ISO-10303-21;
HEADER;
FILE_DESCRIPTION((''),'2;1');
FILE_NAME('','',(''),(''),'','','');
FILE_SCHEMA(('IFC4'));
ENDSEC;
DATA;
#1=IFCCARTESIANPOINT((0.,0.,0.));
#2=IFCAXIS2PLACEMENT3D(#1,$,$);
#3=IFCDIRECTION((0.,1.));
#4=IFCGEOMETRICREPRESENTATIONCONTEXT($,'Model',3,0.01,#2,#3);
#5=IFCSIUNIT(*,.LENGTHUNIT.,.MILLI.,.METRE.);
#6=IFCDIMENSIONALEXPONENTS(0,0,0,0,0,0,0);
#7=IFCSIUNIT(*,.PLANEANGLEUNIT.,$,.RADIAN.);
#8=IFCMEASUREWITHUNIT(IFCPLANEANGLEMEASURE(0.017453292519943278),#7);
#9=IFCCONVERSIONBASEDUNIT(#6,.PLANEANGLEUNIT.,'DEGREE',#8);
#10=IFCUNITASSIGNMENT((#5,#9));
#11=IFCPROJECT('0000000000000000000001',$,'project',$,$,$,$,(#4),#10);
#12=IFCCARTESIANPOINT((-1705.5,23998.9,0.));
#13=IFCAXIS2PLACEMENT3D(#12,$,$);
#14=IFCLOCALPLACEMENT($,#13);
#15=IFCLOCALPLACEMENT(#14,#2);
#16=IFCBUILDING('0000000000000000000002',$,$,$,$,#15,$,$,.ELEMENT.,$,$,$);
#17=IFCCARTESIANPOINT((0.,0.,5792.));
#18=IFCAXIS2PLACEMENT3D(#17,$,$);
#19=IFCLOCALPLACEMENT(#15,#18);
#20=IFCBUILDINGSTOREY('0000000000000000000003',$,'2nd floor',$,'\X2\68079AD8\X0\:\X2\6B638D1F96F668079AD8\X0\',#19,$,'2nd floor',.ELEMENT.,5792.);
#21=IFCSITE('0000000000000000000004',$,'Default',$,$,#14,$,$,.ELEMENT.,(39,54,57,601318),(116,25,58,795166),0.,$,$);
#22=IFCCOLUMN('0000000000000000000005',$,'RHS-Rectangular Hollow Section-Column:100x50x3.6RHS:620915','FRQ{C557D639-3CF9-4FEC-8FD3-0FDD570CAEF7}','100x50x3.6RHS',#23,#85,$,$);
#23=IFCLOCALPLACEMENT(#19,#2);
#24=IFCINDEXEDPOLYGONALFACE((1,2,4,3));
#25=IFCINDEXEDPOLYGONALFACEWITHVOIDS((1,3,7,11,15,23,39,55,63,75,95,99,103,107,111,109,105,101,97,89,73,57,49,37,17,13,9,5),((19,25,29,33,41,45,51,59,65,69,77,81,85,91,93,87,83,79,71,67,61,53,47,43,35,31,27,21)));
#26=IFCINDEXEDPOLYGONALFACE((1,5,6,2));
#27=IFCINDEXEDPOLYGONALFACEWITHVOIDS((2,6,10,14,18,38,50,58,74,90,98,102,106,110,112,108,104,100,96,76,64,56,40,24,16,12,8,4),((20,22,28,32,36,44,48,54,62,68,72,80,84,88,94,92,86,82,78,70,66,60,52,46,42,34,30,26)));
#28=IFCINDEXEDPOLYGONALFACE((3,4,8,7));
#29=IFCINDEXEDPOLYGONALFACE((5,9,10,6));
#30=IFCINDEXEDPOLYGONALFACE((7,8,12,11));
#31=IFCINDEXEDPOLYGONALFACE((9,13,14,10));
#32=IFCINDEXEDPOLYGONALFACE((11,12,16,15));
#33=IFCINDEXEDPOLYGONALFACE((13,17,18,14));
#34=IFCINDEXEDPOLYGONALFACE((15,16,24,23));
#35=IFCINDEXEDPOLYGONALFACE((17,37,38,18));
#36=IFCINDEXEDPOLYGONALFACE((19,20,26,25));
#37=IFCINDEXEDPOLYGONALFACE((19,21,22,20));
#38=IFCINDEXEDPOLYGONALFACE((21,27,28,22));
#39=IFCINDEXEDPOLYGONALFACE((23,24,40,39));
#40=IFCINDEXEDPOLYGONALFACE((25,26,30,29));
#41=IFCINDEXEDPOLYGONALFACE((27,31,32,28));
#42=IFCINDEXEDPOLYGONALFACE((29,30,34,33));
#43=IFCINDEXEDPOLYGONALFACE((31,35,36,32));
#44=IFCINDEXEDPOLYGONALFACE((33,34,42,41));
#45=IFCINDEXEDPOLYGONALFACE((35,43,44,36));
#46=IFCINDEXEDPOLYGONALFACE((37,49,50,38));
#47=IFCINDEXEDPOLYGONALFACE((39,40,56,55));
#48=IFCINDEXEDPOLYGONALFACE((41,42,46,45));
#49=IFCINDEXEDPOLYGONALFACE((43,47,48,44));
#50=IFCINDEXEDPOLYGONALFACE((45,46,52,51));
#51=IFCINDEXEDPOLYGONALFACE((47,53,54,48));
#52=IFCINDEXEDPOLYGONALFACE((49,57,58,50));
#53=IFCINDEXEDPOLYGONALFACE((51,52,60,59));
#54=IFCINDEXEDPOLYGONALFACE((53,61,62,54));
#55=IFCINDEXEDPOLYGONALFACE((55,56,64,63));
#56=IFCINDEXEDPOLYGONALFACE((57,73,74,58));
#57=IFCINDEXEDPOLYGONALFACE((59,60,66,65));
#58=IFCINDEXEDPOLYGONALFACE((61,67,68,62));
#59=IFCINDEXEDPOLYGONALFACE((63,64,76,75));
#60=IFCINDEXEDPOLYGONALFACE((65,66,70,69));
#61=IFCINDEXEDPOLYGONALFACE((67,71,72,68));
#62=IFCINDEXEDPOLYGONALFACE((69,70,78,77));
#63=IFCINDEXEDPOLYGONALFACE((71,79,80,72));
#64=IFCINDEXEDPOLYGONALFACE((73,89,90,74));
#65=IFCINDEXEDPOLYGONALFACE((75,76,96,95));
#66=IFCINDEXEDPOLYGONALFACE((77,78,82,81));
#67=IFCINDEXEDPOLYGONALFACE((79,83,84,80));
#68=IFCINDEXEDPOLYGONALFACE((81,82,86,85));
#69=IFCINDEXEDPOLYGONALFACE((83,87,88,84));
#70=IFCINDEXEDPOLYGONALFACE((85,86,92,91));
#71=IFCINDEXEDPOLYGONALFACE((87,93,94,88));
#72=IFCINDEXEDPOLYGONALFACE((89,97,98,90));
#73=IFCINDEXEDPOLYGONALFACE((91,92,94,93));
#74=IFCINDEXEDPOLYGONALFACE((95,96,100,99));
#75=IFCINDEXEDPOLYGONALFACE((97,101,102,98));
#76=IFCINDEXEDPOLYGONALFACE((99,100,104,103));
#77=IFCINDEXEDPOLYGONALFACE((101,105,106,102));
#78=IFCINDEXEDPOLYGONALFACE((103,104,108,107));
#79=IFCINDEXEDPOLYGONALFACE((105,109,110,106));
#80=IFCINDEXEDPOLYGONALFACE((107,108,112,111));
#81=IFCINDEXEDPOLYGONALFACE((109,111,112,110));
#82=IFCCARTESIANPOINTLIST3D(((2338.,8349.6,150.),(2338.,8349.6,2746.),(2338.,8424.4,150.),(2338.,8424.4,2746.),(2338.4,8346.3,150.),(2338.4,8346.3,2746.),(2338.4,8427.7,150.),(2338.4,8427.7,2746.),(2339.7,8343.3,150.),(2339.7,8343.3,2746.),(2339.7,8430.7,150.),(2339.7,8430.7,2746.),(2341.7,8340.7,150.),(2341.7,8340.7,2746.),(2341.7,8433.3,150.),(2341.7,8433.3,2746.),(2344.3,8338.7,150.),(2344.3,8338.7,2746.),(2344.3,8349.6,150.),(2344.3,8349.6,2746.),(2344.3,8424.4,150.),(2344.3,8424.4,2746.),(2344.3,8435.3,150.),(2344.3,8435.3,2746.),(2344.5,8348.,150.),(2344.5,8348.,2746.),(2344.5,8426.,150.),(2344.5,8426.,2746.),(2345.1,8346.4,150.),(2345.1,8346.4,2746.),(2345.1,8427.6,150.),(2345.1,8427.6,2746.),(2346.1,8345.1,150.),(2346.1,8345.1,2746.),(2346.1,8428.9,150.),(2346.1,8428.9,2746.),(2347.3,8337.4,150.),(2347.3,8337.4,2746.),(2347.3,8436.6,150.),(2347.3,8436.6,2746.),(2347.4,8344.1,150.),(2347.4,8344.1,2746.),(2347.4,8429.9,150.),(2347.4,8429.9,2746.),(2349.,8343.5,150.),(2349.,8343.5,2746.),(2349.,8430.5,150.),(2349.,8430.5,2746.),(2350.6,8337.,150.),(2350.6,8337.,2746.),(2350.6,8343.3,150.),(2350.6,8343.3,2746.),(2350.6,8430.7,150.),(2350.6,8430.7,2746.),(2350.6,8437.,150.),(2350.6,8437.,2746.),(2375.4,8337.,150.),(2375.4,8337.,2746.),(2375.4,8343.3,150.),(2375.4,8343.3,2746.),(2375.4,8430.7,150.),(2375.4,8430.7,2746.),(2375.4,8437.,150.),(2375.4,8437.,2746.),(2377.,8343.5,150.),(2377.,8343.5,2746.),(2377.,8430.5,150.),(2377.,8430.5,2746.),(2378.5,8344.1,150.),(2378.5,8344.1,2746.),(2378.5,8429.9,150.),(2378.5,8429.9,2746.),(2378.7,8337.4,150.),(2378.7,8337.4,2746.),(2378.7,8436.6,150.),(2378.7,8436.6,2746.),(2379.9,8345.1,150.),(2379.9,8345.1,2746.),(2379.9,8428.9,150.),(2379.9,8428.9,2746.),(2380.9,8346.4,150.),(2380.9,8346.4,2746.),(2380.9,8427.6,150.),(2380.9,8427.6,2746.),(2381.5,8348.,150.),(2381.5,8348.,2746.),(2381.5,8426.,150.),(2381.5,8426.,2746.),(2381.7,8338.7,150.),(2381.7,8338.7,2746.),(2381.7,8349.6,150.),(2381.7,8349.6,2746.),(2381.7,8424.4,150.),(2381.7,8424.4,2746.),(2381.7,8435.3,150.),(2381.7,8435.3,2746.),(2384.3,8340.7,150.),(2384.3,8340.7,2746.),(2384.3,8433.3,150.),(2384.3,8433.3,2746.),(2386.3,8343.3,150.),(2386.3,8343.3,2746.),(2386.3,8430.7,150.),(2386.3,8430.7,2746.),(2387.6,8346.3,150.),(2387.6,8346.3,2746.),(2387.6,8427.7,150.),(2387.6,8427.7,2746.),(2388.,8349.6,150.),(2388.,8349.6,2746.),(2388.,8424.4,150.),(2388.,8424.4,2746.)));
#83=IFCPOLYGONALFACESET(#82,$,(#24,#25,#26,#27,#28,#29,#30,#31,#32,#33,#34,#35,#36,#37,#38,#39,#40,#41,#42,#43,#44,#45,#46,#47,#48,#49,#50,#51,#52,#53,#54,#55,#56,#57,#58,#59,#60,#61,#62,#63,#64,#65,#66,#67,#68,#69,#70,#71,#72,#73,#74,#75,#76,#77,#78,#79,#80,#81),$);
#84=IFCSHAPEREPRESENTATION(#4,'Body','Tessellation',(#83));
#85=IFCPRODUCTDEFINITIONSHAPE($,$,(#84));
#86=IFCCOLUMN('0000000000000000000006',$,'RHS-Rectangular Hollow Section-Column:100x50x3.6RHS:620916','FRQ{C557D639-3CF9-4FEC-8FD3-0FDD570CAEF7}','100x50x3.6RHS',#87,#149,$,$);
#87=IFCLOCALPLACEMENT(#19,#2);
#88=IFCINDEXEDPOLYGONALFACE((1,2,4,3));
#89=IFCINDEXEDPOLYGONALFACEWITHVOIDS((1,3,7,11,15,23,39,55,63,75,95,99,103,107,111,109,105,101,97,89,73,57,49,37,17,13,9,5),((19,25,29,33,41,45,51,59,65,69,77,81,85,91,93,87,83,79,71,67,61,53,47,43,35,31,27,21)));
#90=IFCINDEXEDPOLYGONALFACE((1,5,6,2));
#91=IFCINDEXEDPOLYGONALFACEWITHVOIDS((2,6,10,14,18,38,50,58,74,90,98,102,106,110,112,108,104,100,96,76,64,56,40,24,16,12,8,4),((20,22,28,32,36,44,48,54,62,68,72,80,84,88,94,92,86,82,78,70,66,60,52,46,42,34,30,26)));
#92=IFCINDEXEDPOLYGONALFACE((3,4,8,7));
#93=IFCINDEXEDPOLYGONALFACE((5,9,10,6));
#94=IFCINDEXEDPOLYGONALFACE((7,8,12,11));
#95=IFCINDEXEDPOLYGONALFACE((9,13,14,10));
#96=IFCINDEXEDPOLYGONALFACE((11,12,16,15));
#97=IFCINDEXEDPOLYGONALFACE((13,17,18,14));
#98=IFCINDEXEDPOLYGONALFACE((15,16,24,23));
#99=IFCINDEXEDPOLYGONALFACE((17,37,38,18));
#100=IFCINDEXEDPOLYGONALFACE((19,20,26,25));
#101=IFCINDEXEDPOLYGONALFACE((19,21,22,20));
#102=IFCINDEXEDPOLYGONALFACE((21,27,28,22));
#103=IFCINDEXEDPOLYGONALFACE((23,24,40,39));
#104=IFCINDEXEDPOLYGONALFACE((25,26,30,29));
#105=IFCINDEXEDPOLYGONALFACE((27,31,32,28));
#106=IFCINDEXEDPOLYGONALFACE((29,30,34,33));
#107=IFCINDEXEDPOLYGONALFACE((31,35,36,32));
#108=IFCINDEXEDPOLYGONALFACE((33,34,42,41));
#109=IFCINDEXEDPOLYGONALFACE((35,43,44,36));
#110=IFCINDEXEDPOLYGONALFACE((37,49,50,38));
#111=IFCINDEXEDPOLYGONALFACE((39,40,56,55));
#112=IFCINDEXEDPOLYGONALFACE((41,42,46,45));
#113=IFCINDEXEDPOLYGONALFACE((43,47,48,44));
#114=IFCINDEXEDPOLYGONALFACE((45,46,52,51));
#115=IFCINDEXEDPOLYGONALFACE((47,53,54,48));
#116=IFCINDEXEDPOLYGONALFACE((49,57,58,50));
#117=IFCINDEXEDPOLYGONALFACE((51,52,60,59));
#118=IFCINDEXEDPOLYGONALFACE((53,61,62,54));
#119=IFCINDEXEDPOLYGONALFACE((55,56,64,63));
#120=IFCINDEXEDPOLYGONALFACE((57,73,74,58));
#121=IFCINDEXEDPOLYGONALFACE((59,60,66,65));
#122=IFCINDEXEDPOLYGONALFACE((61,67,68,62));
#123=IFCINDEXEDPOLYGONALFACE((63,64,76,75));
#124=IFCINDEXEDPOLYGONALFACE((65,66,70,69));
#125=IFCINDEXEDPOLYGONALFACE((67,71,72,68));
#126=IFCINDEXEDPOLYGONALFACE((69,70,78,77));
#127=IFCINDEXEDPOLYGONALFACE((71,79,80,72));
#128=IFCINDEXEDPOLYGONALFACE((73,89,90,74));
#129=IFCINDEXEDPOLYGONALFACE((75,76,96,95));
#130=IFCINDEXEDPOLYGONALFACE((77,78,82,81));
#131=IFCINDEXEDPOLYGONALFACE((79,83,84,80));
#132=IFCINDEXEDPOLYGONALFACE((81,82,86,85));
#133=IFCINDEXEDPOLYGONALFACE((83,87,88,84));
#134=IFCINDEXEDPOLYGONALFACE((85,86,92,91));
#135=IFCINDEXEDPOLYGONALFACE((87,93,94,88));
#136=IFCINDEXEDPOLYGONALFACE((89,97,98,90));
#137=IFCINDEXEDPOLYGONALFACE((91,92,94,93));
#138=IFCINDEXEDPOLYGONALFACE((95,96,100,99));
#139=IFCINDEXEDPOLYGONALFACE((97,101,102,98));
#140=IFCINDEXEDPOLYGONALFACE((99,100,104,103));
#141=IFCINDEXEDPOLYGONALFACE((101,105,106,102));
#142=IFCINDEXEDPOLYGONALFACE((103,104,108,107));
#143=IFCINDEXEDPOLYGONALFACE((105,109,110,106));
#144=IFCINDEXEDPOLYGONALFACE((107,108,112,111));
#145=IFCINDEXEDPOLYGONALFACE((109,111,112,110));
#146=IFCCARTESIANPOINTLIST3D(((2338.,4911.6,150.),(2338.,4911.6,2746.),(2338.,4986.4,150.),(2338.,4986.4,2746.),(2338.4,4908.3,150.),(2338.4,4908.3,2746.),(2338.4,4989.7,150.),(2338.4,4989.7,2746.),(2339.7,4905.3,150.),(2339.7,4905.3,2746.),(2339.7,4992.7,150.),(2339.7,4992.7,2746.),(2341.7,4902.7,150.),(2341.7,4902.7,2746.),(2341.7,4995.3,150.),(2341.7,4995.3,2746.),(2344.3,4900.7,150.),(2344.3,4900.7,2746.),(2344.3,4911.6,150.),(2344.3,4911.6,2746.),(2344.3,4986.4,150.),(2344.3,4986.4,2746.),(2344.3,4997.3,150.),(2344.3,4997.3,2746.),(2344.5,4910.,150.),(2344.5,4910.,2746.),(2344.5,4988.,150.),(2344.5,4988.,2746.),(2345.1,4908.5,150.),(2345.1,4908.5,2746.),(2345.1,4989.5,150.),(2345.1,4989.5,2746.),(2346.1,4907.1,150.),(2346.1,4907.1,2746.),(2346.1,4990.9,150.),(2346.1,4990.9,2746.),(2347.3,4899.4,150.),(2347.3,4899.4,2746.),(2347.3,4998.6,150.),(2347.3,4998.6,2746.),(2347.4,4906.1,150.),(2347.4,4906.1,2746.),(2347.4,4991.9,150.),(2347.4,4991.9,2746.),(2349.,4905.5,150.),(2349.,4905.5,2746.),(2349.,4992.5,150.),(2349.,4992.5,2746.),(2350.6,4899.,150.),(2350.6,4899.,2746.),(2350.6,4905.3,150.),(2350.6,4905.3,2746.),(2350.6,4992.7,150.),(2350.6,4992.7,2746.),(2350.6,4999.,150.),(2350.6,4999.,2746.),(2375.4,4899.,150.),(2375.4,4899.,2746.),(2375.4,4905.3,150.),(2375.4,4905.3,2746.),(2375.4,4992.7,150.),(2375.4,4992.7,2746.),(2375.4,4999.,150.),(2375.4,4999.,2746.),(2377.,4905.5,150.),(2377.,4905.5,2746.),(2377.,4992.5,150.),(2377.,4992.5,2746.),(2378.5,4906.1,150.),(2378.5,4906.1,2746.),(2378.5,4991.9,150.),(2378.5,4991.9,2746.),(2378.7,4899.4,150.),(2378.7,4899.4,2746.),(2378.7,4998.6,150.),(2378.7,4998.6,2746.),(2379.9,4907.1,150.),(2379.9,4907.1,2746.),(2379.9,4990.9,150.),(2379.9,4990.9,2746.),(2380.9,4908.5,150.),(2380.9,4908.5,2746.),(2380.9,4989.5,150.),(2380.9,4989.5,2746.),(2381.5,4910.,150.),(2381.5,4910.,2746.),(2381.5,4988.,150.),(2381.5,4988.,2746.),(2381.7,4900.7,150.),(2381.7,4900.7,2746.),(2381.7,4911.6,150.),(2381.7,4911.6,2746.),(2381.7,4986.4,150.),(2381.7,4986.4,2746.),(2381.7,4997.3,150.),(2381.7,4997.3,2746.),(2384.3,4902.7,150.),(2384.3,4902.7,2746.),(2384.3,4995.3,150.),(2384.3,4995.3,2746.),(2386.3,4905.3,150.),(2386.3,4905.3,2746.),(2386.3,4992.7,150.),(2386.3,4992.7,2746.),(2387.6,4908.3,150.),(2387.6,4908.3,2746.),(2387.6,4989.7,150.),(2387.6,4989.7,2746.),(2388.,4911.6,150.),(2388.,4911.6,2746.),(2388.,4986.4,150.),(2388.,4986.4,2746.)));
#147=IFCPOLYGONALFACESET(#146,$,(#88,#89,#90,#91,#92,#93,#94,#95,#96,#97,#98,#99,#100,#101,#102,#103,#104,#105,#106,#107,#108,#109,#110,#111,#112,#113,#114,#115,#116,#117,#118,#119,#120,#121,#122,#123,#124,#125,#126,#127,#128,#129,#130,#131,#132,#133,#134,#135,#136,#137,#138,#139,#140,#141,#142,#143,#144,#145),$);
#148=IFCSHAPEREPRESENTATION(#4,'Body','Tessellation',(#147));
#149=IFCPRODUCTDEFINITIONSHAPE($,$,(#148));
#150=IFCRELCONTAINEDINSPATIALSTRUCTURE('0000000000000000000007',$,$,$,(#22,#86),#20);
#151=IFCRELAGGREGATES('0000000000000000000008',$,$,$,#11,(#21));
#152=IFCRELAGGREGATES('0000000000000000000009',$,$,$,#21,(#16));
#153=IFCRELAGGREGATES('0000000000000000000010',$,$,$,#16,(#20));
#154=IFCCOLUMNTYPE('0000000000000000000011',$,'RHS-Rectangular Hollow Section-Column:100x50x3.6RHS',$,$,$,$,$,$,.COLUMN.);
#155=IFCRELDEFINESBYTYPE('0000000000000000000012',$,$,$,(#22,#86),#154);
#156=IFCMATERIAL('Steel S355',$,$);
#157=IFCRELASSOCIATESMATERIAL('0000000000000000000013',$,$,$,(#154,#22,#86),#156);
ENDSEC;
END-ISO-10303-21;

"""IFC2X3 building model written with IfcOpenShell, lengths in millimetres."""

from ifc_helpers import new_model, entity, si_unit, converted_unit, direction, frame, origin, origin_2d, place, context, project, spatial, hollow_rectangle, extrude, clip, halfspace, material, type_object, element, save


model = new_model("IFC2X3")

# Units and contexts
model_context = context("Model", 3, precision=0.01, world=origin(), true_north=direction((0.0, 1.0)))
ifc_project = project(units=[si_unit("LENGTHUNIT", "METRE", prefix="MILLI"), converted_unit("PLANEANGLEUNIT", "DEGREE", entity("IfcPlaneAngleMeasure", 0.017453292519943278), si_unit("PLANEANGLEUNIT", "RADIAN"), dimensions=[0, 0, 0, 0, 0, 0, 0])], contexts=[model_context])

# Site, building, storey
site_placement = place(None, frame((-1705.5, 23998.9, 0.0)))
site = spatial("IfcSite", under=ifc_project, at=site_placement, Name="Default", CompositionType="ELEMENT", RefLatitude=(39, 54, 57, 601318), RefLongitude=(116, 25, 58, 795166), RefElevation=0.0)
building_placement = place(site_placement, origin())
building = spatial("IfcBuilding", under=site, at=building_placement, CompositionType="ELEMENT")
storey_placement = place(building_placement, frame((0.0, 0.0, 5792.0)))
storey = spatial("IfcBuildingStorey", under=building, at=storey_placement, Name="2nd floor", ObjectType="标高:正负零标高", LongName="2nd floor", CompositionType="ELEMENT", Elevation=5792.0)

# Shared definitions
ifc_material_1 = material(Name="Steel S355")

# Columns
column_type_1 = type_object("IfcColumnType", Name="RHS-Rectangular Hollow Section-Column:100x50x3.6RHS", PredefinedType="COLUMN", material=ifc_material_1)
column_1_placement = place(storey_placement, frame((2363.0, 8387.0, 2746.0), z_axis=(0.0, 0.0, 1.0), x_axis=(-1.0, 0.0, 0.0)))
element("IfcColumn", 1, at=column_1_placement, inside=storey, type_object=column_type_1, material=ifc_material_1, Name="RHS-Rectangular Hollow Section-Column:100x50x3.6RHS:620915", Description="FRQ{C557D639-3CF9-4FEC-8FD3-0FDD570CAEF7}", ObjectType="100x50x3.6RHS", context=model_context, shape_type="Clipping", body=[
    clip(extrude(hollow_rectangle(XDim=50.0, YDim=100.0, WallThickness=6.3, InnerFilletRadius=6.3, OuterFilletRadius=12.6, at=origin_2d()), origin(), (0.0, 0.0, -1.0), 2651.9), halfspace(frame((2363.0, 8387.0, -2596.0), z_axis=(0.0, 0.0, 1.0), x_axis=(-1.0, 0.0, 0.0)), True)),
])
column_2_placement = place(storey_placement, frame((2363.0, 4949.0, 2746.0), z_axis=(0.0, 0.0, 1.0), x_axis=(-1.0, 0.0, 0.0)))
element("IfcColumn", 2, at=column_2_placement, inside=storey, type_object=column_type_1, material=ifc_material_1, Name="RHS-Rectangular Hollow Section-Column:100x50x3.6RHS:620916", Description="FRQ{C557D639-3CF9-4FEC-8FD3-0FDD570CAEF7}", ObjectType="100x50x3.6RHS", context=model_context, shape_type="Clipping", body=[
    clip(extrude(hollow_rectangle(XDim=50.0, YDim=100.0, WallThickness=6.3, InnerFilletRadius=6.3, OuterFilletRadius=12.6, at=origin_2d()), origin(), (0.0, 0.0, -1.0), 2651.9), halfspace(frame((2363.0, 4949.0, -2596.0), z_axis=(0.0, 0.0, 1.0), x_axis=(-1.0, 0.0, 0.0)), True)),
])

save(model, "model.ifc")
